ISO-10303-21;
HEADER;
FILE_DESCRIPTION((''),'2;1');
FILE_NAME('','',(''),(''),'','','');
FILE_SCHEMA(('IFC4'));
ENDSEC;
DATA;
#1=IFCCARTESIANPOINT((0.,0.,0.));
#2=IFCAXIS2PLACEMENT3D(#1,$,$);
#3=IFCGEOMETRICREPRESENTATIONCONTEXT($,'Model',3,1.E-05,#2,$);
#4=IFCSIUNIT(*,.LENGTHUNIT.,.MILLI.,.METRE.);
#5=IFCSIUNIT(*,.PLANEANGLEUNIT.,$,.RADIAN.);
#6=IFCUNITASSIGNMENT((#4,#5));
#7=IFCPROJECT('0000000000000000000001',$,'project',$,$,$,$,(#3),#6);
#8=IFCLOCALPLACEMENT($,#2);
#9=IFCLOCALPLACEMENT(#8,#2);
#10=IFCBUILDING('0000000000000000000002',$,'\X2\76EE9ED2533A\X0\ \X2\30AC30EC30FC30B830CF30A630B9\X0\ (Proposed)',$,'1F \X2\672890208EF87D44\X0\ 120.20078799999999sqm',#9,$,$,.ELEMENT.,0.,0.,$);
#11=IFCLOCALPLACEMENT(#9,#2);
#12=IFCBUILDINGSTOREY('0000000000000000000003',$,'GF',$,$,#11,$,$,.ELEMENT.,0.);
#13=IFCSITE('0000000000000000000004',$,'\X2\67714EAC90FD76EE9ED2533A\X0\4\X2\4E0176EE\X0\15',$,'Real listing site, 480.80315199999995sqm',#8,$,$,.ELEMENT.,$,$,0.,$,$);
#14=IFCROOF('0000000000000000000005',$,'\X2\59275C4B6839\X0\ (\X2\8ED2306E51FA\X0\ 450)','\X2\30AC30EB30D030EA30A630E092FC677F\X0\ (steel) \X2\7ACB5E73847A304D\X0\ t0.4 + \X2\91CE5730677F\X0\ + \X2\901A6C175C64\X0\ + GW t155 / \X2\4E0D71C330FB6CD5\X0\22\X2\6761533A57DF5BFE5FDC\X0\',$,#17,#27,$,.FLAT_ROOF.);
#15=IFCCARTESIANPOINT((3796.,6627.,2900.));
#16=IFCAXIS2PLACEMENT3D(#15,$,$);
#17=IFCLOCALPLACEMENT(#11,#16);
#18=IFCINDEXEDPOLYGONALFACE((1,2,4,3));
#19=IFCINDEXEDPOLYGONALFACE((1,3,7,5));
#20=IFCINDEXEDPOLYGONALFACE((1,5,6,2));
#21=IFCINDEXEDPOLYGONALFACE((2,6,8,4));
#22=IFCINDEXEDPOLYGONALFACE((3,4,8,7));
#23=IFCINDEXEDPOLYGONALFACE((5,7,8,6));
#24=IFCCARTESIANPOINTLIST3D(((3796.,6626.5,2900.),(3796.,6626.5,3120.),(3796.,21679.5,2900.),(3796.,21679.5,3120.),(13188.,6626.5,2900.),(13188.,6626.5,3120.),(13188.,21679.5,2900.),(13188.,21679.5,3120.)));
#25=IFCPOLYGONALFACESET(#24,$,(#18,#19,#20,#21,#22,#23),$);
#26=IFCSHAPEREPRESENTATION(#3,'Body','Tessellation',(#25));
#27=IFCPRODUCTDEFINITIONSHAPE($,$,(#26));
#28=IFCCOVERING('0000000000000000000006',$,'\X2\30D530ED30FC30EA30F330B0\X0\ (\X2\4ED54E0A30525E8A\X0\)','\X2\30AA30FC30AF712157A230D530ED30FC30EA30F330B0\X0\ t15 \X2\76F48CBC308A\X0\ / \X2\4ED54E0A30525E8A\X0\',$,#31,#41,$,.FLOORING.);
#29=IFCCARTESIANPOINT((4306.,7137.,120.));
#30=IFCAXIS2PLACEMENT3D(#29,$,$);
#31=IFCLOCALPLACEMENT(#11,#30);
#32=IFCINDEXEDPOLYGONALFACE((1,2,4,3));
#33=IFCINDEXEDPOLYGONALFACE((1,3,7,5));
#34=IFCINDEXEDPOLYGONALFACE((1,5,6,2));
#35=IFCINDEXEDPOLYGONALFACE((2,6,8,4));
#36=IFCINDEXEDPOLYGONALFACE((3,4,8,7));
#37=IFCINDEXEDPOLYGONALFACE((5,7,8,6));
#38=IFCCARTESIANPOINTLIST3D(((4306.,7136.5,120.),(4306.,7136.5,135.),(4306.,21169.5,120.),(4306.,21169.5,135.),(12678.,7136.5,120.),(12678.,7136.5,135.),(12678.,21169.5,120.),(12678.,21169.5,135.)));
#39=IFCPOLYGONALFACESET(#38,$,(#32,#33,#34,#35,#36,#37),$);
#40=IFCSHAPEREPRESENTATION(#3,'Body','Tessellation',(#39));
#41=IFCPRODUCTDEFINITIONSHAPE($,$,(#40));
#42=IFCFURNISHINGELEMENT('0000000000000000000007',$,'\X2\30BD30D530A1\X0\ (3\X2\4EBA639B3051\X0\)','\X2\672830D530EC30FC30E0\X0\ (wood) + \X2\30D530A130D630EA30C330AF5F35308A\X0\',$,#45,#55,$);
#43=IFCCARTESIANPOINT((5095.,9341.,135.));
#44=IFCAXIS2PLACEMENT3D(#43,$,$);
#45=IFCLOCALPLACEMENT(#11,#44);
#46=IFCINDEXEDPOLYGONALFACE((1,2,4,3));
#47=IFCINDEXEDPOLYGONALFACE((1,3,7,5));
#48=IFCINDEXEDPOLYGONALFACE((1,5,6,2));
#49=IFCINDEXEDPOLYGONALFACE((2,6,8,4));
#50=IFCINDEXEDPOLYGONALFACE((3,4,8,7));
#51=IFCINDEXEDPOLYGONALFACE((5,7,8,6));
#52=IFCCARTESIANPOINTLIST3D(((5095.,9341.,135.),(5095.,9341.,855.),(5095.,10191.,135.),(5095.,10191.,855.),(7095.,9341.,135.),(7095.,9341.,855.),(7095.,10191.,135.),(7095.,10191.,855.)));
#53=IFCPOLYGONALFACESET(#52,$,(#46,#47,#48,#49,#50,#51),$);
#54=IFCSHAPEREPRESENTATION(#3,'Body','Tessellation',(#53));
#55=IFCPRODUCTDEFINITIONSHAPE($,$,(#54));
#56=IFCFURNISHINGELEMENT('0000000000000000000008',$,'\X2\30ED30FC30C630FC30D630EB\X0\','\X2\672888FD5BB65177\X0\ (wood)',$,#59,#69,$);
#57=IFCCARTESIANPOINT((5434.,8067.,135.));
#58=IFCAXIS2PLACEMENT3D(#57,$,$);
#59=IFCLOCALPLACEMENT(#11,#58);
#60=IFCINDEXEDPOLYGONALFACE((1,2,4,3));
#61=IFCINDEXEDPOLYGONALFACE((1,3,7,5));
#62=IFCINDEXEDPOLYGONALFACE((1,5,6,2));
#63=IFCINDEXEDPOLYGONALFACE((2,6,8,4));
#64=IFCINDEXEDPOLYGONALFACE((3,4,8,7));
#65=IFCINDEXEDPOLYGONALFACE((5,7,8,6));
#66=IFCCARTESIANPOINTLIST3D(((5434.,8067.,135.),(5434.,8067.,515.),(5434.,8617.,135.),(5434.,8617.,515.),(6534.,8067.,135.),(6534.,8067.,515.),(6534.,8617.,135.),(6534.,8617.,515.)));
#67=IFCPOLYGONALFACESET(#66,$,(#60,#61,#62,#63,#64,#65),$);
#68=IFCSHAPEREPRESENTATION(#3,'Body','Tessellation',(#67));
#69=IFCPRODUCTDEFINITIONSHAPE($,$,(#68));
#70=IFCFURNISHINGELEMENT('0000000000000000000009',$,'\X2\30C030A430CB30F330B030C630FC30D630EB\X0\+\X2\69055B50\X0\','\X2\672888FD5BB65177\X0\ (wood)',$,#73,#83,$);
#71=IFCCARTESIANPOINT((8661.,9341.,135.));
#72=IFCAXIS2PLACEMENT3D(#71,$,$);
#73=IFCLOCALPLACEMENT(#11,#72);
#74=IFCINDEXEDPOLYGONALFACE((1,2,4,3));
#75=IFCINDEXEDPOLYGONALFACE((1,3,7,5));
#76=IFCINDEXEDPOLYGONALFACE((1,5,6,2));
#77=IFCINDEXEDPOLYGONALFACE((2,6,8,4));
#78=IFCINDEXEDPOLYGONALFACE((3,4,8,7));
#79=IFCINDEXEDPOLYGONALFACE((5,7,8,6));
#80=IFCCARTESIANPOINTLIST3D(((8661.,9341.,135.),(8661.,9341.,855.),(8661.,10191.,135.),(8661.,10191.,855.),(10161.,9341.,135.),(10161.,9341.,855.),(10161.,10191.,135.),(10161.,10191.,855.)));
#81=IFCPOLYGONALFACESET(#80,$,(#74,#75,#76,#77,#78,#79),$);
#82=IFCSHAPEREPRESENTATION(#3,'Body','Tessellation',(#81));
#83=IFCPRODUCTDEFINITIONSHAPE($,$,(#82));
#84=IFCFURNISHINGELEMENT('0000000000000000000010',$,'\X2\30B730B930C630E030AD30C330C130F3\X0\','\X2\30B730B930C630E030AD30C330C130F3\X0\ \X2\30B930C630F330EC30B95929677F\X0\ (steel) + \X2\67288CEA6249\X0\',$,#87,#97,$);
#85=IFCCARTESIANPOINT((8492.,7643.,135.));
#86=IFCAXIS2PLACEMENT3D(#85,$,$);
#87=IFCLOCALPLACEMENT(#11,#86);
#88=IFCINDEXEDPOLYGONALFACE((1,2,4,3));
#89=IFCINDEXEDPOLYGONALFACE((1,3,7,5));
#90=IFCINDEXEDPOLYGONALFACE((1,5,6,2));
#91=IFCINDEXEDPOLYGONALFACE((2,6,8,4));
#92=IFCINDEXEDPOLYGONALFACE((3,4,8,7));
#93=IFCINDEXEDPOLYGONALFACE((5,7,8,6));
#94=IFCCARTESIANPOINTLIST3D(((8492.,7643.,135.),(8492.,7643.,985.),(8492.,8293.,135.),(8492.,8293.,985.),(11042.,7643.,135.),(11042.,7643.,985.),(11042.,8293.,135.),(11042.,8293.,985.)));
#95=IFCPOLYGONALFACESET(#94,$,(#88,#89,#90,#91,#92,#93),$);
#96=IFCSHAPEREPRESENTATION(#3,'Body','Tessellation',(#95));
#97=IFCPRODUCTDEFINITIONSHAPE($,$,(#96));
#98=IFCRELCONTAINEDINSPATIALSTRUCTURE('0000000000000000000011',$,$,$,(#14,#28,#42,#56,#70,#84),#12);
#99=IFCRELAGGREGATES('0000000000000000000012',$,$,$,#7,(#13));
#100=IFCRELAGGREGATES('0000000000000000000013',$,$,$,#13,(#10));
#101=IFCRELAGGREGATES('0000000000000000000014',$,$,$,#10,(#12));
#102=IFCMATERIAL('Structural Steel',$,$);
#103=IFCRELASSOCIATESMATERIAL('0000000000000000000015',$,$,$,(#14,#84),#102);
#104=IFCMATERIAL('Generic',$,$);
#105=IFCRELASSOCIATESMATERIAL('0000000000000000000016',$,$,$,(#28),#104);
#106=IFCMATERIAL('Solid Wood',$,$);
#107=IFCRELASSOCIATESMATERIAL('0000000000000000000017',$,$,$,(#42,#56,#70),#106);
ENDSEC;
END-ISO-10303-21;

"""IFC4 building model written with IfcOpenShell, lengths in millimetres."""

from ifc_helpers import new_model, si_unit, frame, frame_2d, origin, place, context, project, spatial, rectangle, extrude, material, element, save


model = new_model("IFC4")

# Units and contexts
model_context = context("Model", 3, precision=1e-05, world=origin())
ifc_project = project(units=[si_unit("LENGTHUNIT", "METRE", prefix="MILLI"), si_unit("PLANEANGLEUNIT", "RADIAN")], contexts=[model_context])

# Site, building, storey
site_placement = place(None, origin())
site = spatial("IfcSite", under=ifc_project, at=site_placement, Name="東京都目黒区4丁目15", ObjectType="Real listing site, 480.80315199999995sqm", CompositionType="ELEMENT", RefElevation=0.0)
building_placement = place(site_placement, origin())
building = spatial("IfcBuilding", under=site, at=building_placement, Name="目黒区 ガレージハウス (Proposed)", ObjectType="1F 木造軸組 120.20078799999999sqm", CompositionType="ELEMENT", ElevationOfRefHeight=0.0, ElevationOfTerrain=0.0)
storey_placement = place(building_placement, origin())
storey = spatial("IfcBuildingStorey", under=building, at=storey_placement, Name="GF", CompositionType="ELEMENT", Elevation=0.0)

# Shared definitions
ifc_material_1 = material(Name="Solid Wood")

# Roof
ifc_material_2 = material(Name="Structural Steel")
roof_placement = place(storey_placement, frame((3796.0, 6627.0, 2900.0)))
element("IfcRoof", 1, at=roof_placement, inside=storey, material=ifc_material_2, Name="大屋根 (軒の出 450)", Description="ガルバリウム鋼板 (steel) 立平葺き t0.4 + 野地板 + 通気層 + GW t155 / 不燃・法22条区域対応", PredefinedType="FLAT_ROOF", context=model_context, shape_type="SweptSolid", body=[
    extrude(rectangle(XDim=9392.0, YDim=15053.0, at=frame_2d((4696.0, 7526.0))), frame((3796.0, 6627.0, 2900.0)), (0.0, 0.0, 1.0), 220.0),
])

# Covering
ifc_material_3 = material(Name="Generic")
covering_placement = place(storey_placement, frame((4306.0, 7137.0, 120.0)))
element("IfcCovering", 2, at=covering_placement, inside=storey, material=ifc_material_3, Name="フローリング (仕上げ床)", Description="オーク無垢フローリング t15 直貼り / 仕上げ床", PredefinedType="FLOORING", context=model_context, shape_type="SweptSolid", body=[
    extrude(rectangle(XDim=8372.0, YDim=14033.0, at=frame_2d((4186.0, 7016.0))), frame((4306.0, 7137.0, 120.0)), (0.0, 0.0, 1.0), 15.0),
])

# Furnishing elements
furnishing_1_placement = place(storey_placement, frame((5095.0, 9341.0, 135.0)))
element("IfcFurnishingElement", 3, at=furnishing_1_placement, inside=storey, material=ifc_material_1, Name="ソファ (3人掛け)", Description="木フレーム (wood) + ファブリック張り", context=model_context, shape_type="SweptSolid", body=[
    extrude(rectangle(XDim=2000.0, YDim=850.0, at=frame_2d((1000.0, 425.0))), frame((5095.0, 9341.0, 135.0)), (0.0, 0.0, 1.0), 720.0),
])
furnishing_2_placement = place(storey_placement, frame((5434.0, 8067.0, 135.0)))
element("IfcFurnishingElement", 4, at=furnishing_2_placement, inside=storey, material=ifc_material_1, Name="ローテーブル", Description="木製家具 (wood)", context=model_context, shape_type="SweptSolid", body=[
    extrude(rectangle(XDim=1100.0, YDim=550.0, at=frame_2d((550.0, 275.0))), frame((5434.0, 8067.0, 135.0)), (0.0, 0.0, 1.0), 380.0),
])
furnishing_3_placement = place(storey_placement, frame((8661.0, 9341.0, 135.0)))
element("IfcFurnishingElement", 5, at=furnishing_3_placement, inside=storey, material=ifc_material_1, Name="ダイニングテーブル+椅子", Description="木製家具 (wood)", context=model_context, shape_type="SweptSolid", body=[
    extrude(rectangle(XDim=1500.0, YDim=850.0, at=frame_2d((750.0, 425.0))), frame((8661.0, 9341.0, 135.0)), (0.0, 0.0, 1.0), 720.0),
])
furnishing_4_placement = place(storey_placement, frame((8492.0, 7643.0, 135.0)))
element("IfcFurnishingElement", 6, at=furnishing_4_placement, inside=storey, material=ifc_material_2, Name="システムキッチン", Description="システムキッチン ステンレス天板 (steel) + 木質扉", context=model_context, shape_type="SweptSolid", body=[
    extrude(rectangle(XDim=2550.0, YDim=650.0, at=frame_2d((1275.0, 325.0))), frame((8492.0, 7643.0, 135.0)), (0.0, 0.0, 1.0), 850.0),
])

save(model, "model.ifc")
